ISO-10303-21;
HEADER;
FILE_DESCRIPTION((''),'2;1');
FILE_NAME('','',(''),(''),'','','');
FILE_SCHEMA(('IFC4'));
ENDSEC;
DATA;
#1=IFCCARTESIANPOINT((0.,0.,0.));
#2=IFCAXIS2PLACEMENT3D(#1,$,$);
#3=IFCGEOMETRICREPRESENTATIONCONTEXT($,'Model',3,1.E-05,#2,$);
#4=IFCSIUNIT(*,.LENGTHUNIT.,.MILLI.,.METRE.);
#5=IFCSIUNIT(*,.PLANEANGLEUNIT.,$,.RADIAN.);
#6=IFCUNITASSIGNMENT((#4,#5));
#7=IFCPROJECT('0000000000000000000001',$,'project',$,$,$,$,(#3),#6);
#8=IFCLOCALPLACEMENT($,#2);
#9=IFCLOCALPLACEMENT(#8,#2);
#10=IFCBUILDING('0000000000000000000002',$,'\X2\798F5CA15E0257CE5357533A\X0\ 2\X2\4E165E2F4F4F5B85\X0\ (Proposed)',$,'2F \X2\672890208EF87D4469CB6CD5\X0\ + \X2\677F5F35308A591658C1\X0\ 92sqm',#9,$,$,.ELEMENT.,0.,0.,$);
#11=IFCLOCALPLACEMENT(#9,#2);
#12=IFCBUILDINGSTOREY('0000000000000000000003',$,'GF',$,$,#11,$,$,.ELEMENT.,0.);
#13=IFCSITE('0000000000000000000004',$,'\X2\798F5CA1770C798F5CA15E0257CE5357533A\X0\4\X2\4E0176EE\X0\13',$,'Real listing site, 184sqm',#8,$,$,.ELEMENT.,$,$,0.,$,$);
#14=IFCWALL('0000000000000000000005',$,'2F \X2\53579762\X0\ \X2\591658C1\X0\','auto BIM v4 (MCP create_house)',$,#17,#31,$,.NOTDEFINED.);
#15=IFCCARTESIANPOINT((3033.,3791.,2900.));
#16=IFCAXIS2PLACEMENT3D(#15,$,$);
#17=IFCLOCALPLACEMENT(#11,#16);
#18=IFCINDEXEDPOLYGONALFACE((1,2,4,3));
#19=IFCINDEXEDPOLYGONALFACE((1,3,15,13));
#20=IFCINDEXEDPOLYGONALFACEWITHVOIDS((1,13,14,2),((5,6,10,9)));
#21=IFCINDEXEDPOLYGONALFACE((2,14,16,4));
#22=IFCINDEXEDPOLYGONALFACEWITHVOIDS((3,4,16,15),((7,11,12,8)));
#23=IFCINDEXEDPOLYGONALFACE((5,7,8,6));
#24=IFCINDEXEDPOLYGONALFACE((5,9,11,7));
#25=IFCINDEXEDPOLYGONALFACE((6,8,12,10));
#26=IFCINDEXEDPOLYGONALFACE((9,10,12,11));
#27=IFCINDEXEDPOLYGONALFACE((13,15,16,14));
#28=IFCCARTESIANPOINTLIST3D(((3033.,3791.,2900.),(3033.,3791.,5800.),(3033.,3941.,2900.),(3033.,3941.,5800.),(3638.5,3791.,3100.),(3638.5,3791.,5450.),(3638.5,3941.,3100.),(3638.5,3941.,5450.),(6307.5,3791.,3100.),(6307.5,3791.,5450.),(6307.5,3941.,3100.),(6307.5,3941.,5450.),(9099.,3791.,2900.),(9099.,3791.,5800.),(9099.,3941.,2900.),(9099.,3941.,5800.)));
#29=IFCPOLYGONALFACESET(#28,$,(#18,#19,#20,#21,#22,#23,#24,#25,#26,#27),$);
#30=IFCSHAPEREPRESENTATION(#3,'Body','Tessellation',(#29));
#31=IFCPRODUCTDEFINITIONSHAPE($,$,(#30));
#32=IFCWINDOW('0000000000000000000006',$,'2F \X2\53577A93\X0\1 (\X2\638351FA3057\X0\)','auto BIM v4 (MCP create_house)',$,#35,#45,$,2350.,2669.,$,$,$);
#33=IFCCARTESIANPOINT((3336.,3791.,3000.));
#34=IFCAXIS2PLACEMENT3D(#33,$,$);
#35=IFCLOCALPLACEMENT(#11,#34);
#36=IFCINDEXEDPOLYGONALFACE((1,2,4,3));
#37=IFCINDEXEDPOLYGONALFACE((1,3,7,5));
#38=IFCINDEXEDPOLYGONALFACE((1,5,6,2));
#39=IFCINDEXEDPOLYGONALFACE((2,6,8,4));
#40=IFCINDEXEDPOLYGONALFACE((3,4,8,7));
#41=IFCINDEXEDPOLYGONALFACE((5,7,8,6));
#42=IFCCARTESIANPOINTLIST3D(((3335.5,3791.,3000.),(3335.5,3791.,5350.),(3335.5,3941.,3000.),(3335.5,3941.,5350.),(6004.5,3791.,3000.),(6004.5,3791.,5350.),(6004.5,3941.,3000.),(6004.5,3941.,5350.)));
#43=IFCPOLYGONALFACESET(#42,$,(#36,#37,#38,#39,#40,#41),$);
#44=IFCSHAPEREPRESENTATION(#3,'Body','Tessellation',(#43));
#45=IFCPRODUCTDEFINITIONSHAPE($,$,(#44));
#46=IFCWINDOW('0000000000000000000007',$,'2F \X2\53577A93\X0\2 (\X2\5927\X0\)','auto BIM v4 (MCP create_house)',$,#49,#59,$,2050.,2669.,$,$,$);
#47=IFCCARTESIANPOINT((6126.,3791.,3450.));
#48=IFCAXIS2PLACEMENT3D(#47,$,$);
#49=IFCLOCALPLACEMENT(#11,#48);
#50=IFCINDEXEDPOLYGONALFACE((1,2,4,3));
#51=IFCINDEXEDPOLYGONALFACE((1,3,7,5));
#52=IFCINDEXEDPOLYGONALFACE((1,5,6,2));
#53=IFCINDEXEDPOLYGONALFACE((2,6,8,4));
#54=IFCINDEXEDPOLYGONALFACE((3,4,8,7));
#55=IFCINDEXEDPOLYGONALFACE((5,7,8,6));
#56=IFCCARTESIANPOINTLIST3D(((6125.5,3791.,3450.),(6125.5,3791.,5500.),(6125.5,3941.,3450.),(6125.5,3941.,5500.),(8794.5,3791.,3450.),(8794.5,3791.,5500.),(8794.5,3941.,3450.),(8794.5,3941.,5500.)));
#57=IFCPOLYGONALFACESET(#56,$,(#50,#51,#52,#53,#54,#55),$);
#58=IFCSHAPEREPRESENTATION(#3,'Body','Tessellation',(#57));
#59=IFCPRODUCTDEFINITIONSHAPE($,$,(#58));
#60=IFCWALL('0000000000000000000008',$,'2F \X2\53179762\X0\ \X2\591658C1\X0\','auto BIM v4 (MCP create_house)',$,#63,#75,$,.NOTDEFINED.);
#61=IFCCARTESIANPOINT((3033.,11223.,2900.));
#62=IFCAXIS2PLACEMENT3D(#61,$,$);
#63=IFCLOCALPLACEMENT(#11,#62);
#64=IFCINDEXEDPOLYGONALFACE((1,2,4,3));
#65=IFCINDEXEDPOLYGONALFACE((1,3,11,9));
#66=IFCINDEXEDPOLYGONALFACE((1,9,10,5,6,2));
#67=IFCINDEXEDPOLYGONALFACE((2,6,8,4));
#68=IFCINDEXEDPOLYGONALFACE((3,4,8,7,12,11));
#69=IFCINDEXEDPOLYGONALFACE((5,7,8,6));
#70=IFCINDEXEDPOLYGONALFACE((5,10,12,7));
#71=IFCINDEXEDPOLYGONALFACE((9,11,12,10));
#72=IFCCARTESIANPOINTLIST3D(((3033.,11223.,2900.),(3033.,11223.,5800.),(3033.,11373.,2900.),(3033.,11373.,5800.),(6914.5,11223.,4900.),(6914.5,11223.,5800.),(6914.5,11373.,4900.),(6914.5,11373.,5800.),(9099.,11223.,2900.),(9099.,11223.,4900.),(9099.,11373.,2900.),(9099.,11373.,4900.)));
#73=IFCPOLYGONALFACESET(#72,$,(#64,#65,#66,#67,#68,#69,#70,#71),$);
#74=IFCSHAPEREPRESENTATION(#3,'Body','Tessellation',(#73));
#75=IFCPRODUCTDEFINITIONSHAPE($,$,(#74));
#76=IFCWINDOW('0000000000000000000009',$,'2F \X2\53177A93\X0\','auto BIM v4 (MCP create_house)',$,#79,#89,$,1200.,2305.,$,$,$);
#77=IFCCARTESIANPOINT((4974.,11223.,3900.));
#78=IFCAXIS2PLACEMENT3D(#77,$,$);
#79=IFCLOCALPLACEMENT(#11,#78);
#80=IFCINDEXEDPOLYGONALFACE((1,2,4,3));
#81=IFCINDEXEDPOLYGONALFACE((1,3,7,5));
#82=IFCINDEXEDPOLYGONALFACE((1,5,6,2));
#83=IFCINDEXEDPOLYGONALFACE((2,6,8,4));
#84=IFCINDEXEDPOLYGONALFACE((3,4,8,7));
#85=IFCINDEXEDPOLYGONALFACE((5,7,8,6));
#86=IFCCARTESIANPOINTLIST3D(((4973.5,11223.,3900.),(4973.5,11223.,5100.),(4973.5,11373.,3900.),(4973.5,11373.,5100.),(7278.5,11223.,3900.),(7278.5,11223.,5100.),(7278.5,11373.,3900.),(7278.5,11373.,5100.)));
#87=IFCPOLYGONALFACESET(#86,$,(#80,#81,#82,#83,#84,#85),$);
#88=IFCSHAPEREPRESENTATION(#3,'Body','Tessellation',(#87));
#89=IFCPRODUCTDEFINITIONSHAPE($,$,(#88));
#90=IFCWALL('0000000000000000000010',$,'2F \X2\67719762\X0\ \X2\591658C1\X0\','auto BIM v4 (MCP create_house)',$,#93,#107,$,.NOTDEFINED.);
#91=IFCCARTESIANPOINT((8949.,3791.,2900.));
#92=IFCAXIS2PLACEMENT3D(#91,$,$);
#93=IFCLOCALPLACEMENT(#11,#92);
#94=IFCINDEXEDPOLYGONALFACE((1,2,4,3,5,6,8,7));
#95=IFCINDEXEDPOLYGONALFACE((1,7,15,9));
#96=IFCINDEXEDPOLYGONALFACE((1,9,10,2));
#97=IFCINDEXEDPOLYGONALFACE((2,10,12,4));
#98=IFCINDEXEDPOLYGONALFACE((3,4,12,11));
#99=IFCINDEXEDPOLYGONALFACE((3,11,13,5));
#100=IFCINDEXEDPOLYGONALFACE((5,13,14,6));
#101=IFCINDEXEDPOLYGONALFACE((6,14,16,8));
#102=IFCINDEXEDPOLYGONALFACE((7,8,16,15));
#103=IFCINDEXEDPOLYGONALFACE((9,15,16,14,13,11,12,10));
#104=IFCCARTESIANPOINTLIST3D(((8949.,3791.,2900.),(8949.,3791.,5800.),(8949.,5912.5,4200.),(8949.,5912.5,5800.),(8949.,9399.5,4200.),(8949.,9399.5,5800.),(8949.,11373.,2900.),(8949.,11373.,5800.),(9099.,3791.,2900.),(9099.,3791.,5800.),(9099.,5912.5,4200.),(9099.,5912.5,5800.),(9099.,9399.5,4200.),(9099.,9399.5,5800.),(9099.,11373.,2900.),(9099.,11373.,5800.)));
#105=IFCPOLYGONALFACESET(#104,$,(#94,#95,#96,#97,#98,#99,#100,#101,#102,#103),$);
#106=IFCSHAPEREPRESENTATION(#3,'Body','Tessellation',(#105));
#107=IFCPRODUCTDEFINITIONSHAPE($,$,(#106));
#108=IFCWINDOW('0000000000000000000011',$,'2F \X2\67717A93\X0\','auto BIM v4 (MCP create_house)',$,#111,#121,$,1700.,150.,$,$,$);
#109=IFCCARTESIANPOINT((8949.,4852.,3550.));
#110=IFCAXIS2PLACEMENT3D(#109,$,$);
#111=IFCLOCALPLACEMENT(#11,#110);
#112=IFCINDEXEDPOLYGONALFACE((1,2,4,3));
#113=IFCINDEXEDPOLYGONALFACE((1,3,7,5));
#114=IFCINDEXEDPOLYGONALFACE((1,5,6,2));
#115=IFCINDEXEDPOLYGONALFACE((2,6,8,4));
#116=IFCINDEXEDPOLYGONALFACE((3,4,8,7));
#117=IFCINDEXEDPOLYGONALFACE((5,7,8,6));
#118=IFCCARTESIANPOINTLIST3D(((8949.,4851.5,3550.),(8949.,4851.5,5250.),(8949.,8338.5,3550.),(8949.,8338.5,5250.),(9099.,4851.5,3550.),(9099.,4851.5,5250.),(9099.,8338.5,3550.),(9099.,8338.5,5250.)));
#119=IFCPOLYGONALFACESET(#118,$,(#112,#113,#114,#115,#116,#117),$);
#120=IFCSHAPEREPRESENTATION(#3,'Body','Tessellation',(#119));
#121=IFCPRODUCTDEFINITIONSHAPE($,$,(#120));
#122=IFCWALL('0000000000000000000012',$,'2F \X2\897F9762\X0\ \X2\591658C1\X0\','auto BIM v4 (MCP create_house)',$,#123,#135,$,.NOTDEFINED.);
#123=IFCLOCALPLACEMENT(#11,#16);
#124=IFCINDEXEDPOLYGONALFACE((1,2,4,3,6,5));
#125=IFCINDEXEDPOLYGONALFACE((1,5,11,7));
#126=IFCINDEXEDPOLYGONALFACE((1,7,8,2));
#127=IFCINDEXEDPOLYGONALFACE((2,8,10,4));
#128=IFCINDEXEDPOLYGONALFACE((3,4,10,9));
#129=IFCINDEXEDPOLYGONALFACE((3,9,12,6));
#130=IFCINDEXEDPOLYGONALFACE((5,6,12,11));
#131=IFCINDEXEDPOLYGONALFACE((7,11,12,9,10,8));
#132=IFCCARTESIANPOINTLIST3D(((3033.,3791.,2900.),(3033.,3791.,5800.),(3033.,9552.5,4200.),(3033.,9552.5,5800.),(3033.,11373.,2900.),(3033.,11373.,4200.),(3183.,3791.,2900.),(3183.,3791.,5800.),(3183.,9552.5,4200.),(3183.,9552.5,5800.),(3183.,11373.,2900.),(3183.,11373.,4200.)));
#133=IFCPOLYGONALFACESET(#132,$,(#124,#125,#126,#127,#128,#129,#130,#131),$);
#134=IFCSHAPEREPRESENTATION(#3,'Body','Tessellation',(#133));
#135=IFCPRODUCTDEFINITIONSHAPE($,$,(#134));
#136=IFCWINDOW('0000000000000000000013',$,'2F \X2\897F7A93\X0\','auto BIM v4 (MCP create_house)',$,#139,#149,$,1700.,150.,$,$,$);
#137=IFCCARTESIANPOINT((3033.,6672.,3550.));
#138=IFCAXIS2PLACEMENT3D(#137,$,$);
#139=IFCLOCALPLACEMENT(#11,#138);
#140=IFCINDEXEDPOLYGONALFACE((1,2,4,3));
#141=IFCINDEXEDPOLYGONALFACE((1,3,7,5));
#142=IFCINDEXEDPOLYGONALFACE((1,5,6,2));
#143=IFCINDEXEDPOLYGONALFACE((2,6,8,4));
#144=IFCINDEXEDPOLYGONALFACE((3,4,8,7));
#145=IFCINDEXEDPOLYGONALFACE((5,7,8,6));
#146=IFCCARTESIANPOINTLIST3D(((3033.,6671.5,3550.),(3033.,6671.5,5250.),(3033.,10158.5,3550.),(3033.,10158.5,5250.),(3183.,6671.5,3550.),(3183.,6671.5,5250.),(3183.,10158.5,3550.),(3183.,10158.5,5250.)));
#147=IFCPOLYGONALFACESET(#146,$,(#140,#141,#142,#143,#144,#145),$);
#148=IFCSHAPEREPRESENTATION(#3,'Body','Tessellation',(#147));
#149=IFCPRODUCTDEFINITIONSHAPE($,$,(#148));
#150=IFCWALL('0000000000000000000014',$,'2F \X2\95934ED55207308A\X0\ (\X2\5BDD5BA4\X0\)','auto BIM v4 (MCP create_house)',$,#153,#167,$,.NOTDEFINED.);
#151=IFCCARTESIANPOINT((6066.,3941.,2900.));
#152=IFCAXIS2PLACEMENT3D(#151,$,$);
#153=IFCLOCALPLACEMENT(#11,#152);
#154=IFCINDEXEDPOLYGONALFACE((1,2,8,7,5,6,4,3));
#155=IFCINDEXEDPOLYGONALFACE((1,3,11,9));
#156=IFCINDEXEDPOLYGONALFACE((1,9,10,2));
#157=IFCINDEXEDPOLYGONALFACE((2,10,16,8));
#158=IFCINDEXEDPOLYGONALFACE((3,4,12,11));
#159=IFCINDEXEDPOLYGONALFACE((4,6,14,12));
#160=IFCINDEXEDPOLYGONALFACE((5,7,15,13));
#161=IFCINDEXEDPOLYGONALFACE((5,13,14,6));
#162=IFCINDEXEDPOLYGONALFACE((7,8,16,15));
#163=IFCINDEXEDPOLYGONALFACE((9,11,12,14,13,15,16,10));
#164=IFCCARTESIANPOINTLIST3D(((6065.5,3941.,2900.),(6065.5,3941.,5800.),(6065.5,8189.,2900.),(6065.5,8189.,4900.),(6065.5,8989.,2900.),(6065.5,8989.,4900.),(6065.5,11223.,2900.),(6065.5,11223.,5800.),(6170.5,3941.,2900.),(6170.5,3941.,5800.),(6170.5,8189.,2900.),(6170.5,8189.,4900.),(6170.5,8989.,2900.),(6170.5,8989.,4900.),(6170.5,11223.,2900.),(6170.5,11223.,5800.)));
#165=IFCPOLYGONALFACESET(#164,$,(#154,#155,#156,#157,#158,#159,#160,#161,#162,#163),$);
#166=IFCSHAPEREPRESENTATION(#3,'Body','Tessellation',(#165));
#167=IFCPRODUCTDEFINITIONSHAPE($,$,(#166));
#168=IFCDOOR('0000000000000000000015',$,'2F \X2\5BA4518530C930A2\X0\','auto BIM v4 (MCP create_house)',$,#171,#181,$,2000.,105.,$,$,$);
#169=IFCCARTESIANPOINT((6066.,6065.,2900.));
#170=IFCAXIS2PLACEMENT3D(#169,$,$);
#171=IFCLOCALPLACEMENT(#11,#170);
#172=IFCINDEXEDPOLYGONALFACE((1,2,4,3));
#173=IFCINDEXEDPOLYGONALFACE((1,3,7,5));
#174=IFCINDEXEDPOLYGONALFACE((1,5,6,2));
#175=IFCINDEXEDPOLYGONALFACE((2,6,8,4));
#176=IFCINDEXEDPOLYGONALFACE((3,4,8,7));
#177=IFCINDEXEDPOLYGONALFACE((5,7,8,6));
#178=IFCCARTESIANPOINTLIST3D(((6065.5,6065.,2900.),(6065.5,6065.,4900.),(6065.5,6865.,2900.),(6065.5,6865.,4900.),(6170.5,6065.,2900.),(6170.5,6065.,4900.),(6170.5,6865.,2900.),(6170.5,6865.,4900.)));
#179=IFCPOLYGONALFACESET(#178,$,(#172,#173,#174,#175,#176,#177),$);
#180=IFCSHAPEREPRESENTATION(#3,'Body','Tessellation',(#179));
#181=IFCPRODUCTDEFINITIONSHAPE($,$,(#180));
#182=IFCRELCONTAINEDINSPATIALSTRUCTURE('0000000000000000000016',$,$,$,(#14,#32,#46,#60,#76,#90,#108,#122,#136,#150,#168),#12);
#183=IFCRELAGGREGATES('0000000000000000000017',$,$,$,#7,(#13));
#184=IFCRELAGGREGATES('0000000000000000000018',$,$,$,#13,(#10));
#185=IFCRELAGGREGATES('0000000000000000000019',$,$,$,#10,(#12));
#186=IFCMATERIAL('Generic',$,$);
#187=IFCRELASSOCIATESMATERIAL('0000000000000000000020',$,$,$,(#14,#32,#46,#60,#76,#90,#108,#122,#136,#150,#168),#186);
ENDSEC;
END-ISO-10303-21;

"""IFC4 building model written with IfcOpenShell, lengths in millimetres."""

from ifc_helpers import new_model, si_unit, frame, frame_2d, origin, place, context, project, spatial, rectangle, extrude, material, element, fill, save


model = new_model("IFC4")

# Units and contexts
model_context = context("Model", 3, precision=1e-05, world=origin())
ifc_project = project(units=[si_unit("LENGTHUNIT", "METRE", prefix="MILLI"), si_unit("PLANEANGLEUNIT", "RADIAN")], contexts=[model_context])

# Site, building, storey
site_placement = place(None, origin())
site = spatial("IfcSite", under=ifc_project, at=site_placement, Name="福岡県福岡市城南区4丁目13", ObjectType="Real listing site, 184sqm", CompositionType="ELEMENT", RefElevation=0.0)
building_placement = place(site_placement, origin())
building = spatial("IfcBuilding", under=site, at=building_placement, Name="福岡市城南区 2世帯住宅 (Proposed)", ObjectType="2F 木造軸組構法 + 板張り外壁 92sqm", CompositionType="ELEMENT", ElevationOfRefHeight=0.0, ElevationOfTerrain=0.0)
storey_placement = place(building_placement, origin())
storey = spatial("IfcBuildingStorey", under=building, at=storey_placement, Name="GF", CompositionType="ELEMENT", Elevation=0.0)

# Shared definitions
ifc_material = material(Name="Generic")

# Wall, openings, windows
wall_1_placement = place(storey_placement, frame((3033.0, 3791.0, 2900.0)))
wall_1 = element("IfcWall", 1, at=wall_1_placement, inside=storey, material=ifc_material, Name="2F 南面 外壁", Description="auto BIM v4 (MCP create_house)", PredefinedType="NOTDEFINED", context=model_context, shape_type="SweptSolid", body=[
    extrude(rectangle(XDim=6066.0, YDim=150.0, at=frame_2d((3033.0, 75.0))), frame((3033.0, 3791.0, 2900.0)), (0.0, 0.0, 1.0), 2900.0),
])
opening_1_placement = place(storey_placement, frame((3336.0, 3791.0, 3000.0)))
opening_1 = element("IfcOpeningElement", 2, at=opening_1_placement, cuts=wall_1, PredefinedType="NOTDEFINED", context=model_context, shape_type="SweptSolid", body=[
    extrude(rectangle(XDim=2669.0, YDim=150.0, at=frame_2d((1334.0, 75.0))), frame((3336.0, 3791.0, 3000.0)), (0.0, 0.0, 1.0), 2350.0),
])
opening_2_placement = place(storey_placement, frame((6126.0, 3791.0, 3450.0)))
opening_2 = element("IfcOpeningElement", 3, at=opening_2_placement, cuts=wall_1, PredefinedType="NOTDEFINED", context=model_context, shape_type="SweptSolid", body=[
    extrude(rectangle(XDim=2669.0, YDim=150.0, at=frame_2d((1334.0, 75.0))), frame((6126.0, 3791.0, 3450.0)), (0.0, 0.0, 1.0), 2050.0),
])
window_1_placement = place(storey_placement, frame((3336.0, 3791.0, 3000.0)))
window_1 = element("IfcWindow", 4, at=window_1_placement, inside=storey, material=ifc_material, Name="2F 南窓1 (掃出し)", Description="auto BIM v4 (MCP create_house)", OverallHeight=2350.0, OverallWidth=2669.0, context=model_context, shape_type="SweptSolid", body=[
    extrude(rectangle(XDim=2669.0, YDim=150.0, at=frame_2d((1334.0, 75.0))), frame((3336.0, 3791.0, 3000.0)), (0.0, 0.0, 1.0), 2350.0),
])
fill(opening_1, window_1)
window_2_placement = place(storey_placement, frame((6126.0, 3791.0, 3450.0)))
window_2 = element("IfcWindow", 5, at=window_2_placement, inside=storey, material=ifc_material, Name="2F 南窓2 (大)", Description="auto BIM v4 (MCP create_house)", OverallHeight=2050.0, OverallWidth=2669.0, context=model_context, shape_type="SweptSolid", body=[
    extrude(rectangle(XDim=2669.0, YDim=150.0, at=frame_2d((1334.0, 75.0))), frame((6126.0, 3791.0, 3450.0)), (0.0, 0.0, 1.0), 2050.0),
])
fill(opening_2, window_2)

# Walls, openings, windows
wall_2_placement = place(storey_placement, frame((3033.0, 11223.0, 2900.0)))
wall_2 = element("IfcWall", 6, at=wall_2_placement, inside=storey, material=ifc_material, Name="2F 北面 外壁", Description="auto BIM v4 (MCP create_house)", PredefinedType="NOTDEFINED", context=model_context, shape_type="SweptSolid", body=[
    extrude(rectangle(XDim=6066.0, YDim=150.0, at=frame_2d((3033.0, 75.0))), frame((3033.0, 11223.0, 2900.0)), (0.0, 0.0, 1.0), 2900.0),
])
opening_3_placement = place(storey_placement, frame((4974.0, 11223.0, 3900.0)))
opening_3 = element("IfcOpeningElement", 7, at=opening_3_placement, cuts=wall_2, PredefinedType="NOTDEFINED", context=model_context, shape_type="SweptSolid", body=[
    extrude(rectangle(XDim=2305.0, YDim=150.0, at=frame_2d((1152.0, 75.0))), frame((4974.0, 11223.0, 3900.0)), (0.0, 0.0, 1.0), 1200.0),
])
window_3_placement = place(storey_placement, frame((4974.0, 11223.0, 3900.0)))
window_3 = element("IfcWindow", 8, at=window_3_placement, inside=storey, material=ifc_material, Name="2F 北窓", Description="auto BIM v4 (MCP create_house)", OverallHeight=1200.0, OverallWidth=2305.0, context=model_context, shape_type="SweptSolid", body=[
    extrude(rectangle(XDim=2305.0, YDim=150.0, at=frame_2d((1152.0, 75.0))), frame((4974.0, 11223.0, 3900.0)), (0.0, 0.0, 1.0), 1200.0),
])
fill(opening_3, window_3)
wall_3_placement = place(storey_placement, frame((8949.0, 3791.0, 2900.0)))
wall_3 = element("IfcWall", 9, at=wall_3_placement, inside=storey, material=ifc_material, Name="2F 東面 外壁", Description="auto BIM v4 (MCP create_house)", PredefinedType="NOTDEFINED", context=model_context, shape_type="SweptSolid", body=[
    extrude(rectangle(XDim=150.0, YDim=7582.0, at=frame_2d((75.0, 3791.0))), frame((8949.0, 3791.0, 2900.0)), (0.0, 0.0, 1.0), 2900.0),
])
opening_4_placement = place(storey_placement, frame((8949.0, 4852.0, 3550.0)))
opening_4 = element("IfcOpeningElement", 10, at=opening_4_placement, cuts=wall_3, PredefinedType="NOTDEFINED", context=model_context, shape_type="SweptSolid", body=[
    extrude(rectangle(XDim=150.0, YDim=3487.0, at=frame_2d((75.0, 1743.0))), frame((8949.0, 4852.0, 3550.0)), (0.0, 0.0, 1.0), 1700.0),
])
window_4_placement = place(storey_placement, frame((8949.0, 4852.0, 3550.0)))
window_4 = element("IfcWindow", 11, at=window_4_placement, inside=storey, material=ifc_material, Name="2F 東窓", Description="auto BIM v4 (MCP create_house)", OverallHeight=1700.0, OverallWidth=150.0, context=model_context, shape_type="SweptSolid", body=[
    extrude(rectangle(XDim=150.0, YDim=3487.0, at=frame_2d((75.0, 1743.0))), frame((8949.0, 4852.0, 3550.0)), (0.0, 0.0, 1.0), 1700.0),
])
fill(opening_4, window_4)
wall_4_placement = place(storey_placement, frame((3033.0, 3791.0, 2900.0)))
wall_4 = element("IfcWall", 12, at=wall_4_placement, inside=storey, material=ifc_material, Name="2F 西面 外壁", Description="auto BIM v4 (MCP create_house)", PredefinedType="NOTDEFINED", context=model_context, shape_type="SweptSolid", body=[
    extrude(rectangle(XDim=150.0, YDim=7582.0, at=frame_2d((75.0, 3791.0))), frame((3033.0, 3791.0, 2900.0)), (0.0, 0.0, 1.0), 2900.0),
])
opening_5_placement = place(storey_placement, frame((3033.0, 6672.0, 3550.0)))
opening_5 = element("IfcOpeningElement", 13, at=opening_5_placement, cuts=wall_4, PredefinedType="NOTDEFINED", context=model_context, shape_type="SweptSolid", body=[
    extrude(rectangle(XDim=150.0, YDim=3487.0, at=frame_2d((75.0, 1743.0))), frame((3033.0, 6672.0, 3550.0)), (0.0, 0.0, 1.0), 1700.0),
])
window_5_placement = place(storey_placement, frame((3033.0, 6672.0, 3550.0)))
window_5 = element("IfcWindow", 14, at=window_5_placement, inside=storey, material=ifc_material, Name="2F 西窓", Description="auto BIM v4 (MCP create_house)", OverallHeight=1700.0, OverallWidth=150.0, context=model_context, shape_type="SweptSolid", body=[
    extrude(rectangle(XDim=150.0, YDim=3487.0, at=frame_2d((75.0, 1743.0))), frame((3033.0, 6672.0, 3550.0)), (0.0, 0.0, 1.0), 1700.0),
])
fill(opening_5, window_5)

# Wall, opening, door
wall_5_placement = place(storey_placement, frame((6066.0, 3941.0, 2900.0)))
wall_5 = element("IfcWall", 15, at=wall_5_placement, inside=storey, material=ifc_material, Name="2F 間仕切り (寝室)", Description="auto BIM v4 (MCP create_house)", PredefinedType="NOTDEFINED", context=model_context, shape_type="SweptSolid", body=[
    extrude(rectangle(XDim=105.0, YDim=7282.0, at=frame_2d((52.0, 3641.0))), frame((6066.0, 3941.0, 2900.0)), (0.0, 0.0, 1.0), 2900.0),
])
opening_6_placement = place(storey_placement, frame((6066.0, 6065.0, 2900.0)))
opening_6 = element("IfcOpeningElement", 16, at=opening_6_placement, cuts=wall_5, PredefinedType="NOTDEFINED", context=model_context, shape_type="SweptSolid", body=[
    extrude(rectangle(XDim=105.0, YDim=800.0, at=frame_2d((52.0, 400.0))), frame((6066.0, 6065.0, 2900.0)), (0.0, 0.0, 1.0), 2000.0),
])
door_1_placement = place(storey_placement, frame((6066.0, 6065.0, 2900.0)))
door_1 = element("IfcDoor", 17, at=door_1_placement, inside=storey, material=ifc_material, Name="2F 室内ドア", Description="auto BIM v4 (MCP create_house)", OverallHeight=2000.0, OverallWidth=105.0, context=model_context, shape_type="SweptSolid", body=[
    extrude(rectangle(XDim=105.0, YDim=800.0, at=frame_2d((52.0, 400.0))), frame((6066.0, 6065.0, 2900.0)), (0.0, 0.0, 1.0), 2000.0),
])
fill(opening_6, door_1)

save(model, "model.ifc")
